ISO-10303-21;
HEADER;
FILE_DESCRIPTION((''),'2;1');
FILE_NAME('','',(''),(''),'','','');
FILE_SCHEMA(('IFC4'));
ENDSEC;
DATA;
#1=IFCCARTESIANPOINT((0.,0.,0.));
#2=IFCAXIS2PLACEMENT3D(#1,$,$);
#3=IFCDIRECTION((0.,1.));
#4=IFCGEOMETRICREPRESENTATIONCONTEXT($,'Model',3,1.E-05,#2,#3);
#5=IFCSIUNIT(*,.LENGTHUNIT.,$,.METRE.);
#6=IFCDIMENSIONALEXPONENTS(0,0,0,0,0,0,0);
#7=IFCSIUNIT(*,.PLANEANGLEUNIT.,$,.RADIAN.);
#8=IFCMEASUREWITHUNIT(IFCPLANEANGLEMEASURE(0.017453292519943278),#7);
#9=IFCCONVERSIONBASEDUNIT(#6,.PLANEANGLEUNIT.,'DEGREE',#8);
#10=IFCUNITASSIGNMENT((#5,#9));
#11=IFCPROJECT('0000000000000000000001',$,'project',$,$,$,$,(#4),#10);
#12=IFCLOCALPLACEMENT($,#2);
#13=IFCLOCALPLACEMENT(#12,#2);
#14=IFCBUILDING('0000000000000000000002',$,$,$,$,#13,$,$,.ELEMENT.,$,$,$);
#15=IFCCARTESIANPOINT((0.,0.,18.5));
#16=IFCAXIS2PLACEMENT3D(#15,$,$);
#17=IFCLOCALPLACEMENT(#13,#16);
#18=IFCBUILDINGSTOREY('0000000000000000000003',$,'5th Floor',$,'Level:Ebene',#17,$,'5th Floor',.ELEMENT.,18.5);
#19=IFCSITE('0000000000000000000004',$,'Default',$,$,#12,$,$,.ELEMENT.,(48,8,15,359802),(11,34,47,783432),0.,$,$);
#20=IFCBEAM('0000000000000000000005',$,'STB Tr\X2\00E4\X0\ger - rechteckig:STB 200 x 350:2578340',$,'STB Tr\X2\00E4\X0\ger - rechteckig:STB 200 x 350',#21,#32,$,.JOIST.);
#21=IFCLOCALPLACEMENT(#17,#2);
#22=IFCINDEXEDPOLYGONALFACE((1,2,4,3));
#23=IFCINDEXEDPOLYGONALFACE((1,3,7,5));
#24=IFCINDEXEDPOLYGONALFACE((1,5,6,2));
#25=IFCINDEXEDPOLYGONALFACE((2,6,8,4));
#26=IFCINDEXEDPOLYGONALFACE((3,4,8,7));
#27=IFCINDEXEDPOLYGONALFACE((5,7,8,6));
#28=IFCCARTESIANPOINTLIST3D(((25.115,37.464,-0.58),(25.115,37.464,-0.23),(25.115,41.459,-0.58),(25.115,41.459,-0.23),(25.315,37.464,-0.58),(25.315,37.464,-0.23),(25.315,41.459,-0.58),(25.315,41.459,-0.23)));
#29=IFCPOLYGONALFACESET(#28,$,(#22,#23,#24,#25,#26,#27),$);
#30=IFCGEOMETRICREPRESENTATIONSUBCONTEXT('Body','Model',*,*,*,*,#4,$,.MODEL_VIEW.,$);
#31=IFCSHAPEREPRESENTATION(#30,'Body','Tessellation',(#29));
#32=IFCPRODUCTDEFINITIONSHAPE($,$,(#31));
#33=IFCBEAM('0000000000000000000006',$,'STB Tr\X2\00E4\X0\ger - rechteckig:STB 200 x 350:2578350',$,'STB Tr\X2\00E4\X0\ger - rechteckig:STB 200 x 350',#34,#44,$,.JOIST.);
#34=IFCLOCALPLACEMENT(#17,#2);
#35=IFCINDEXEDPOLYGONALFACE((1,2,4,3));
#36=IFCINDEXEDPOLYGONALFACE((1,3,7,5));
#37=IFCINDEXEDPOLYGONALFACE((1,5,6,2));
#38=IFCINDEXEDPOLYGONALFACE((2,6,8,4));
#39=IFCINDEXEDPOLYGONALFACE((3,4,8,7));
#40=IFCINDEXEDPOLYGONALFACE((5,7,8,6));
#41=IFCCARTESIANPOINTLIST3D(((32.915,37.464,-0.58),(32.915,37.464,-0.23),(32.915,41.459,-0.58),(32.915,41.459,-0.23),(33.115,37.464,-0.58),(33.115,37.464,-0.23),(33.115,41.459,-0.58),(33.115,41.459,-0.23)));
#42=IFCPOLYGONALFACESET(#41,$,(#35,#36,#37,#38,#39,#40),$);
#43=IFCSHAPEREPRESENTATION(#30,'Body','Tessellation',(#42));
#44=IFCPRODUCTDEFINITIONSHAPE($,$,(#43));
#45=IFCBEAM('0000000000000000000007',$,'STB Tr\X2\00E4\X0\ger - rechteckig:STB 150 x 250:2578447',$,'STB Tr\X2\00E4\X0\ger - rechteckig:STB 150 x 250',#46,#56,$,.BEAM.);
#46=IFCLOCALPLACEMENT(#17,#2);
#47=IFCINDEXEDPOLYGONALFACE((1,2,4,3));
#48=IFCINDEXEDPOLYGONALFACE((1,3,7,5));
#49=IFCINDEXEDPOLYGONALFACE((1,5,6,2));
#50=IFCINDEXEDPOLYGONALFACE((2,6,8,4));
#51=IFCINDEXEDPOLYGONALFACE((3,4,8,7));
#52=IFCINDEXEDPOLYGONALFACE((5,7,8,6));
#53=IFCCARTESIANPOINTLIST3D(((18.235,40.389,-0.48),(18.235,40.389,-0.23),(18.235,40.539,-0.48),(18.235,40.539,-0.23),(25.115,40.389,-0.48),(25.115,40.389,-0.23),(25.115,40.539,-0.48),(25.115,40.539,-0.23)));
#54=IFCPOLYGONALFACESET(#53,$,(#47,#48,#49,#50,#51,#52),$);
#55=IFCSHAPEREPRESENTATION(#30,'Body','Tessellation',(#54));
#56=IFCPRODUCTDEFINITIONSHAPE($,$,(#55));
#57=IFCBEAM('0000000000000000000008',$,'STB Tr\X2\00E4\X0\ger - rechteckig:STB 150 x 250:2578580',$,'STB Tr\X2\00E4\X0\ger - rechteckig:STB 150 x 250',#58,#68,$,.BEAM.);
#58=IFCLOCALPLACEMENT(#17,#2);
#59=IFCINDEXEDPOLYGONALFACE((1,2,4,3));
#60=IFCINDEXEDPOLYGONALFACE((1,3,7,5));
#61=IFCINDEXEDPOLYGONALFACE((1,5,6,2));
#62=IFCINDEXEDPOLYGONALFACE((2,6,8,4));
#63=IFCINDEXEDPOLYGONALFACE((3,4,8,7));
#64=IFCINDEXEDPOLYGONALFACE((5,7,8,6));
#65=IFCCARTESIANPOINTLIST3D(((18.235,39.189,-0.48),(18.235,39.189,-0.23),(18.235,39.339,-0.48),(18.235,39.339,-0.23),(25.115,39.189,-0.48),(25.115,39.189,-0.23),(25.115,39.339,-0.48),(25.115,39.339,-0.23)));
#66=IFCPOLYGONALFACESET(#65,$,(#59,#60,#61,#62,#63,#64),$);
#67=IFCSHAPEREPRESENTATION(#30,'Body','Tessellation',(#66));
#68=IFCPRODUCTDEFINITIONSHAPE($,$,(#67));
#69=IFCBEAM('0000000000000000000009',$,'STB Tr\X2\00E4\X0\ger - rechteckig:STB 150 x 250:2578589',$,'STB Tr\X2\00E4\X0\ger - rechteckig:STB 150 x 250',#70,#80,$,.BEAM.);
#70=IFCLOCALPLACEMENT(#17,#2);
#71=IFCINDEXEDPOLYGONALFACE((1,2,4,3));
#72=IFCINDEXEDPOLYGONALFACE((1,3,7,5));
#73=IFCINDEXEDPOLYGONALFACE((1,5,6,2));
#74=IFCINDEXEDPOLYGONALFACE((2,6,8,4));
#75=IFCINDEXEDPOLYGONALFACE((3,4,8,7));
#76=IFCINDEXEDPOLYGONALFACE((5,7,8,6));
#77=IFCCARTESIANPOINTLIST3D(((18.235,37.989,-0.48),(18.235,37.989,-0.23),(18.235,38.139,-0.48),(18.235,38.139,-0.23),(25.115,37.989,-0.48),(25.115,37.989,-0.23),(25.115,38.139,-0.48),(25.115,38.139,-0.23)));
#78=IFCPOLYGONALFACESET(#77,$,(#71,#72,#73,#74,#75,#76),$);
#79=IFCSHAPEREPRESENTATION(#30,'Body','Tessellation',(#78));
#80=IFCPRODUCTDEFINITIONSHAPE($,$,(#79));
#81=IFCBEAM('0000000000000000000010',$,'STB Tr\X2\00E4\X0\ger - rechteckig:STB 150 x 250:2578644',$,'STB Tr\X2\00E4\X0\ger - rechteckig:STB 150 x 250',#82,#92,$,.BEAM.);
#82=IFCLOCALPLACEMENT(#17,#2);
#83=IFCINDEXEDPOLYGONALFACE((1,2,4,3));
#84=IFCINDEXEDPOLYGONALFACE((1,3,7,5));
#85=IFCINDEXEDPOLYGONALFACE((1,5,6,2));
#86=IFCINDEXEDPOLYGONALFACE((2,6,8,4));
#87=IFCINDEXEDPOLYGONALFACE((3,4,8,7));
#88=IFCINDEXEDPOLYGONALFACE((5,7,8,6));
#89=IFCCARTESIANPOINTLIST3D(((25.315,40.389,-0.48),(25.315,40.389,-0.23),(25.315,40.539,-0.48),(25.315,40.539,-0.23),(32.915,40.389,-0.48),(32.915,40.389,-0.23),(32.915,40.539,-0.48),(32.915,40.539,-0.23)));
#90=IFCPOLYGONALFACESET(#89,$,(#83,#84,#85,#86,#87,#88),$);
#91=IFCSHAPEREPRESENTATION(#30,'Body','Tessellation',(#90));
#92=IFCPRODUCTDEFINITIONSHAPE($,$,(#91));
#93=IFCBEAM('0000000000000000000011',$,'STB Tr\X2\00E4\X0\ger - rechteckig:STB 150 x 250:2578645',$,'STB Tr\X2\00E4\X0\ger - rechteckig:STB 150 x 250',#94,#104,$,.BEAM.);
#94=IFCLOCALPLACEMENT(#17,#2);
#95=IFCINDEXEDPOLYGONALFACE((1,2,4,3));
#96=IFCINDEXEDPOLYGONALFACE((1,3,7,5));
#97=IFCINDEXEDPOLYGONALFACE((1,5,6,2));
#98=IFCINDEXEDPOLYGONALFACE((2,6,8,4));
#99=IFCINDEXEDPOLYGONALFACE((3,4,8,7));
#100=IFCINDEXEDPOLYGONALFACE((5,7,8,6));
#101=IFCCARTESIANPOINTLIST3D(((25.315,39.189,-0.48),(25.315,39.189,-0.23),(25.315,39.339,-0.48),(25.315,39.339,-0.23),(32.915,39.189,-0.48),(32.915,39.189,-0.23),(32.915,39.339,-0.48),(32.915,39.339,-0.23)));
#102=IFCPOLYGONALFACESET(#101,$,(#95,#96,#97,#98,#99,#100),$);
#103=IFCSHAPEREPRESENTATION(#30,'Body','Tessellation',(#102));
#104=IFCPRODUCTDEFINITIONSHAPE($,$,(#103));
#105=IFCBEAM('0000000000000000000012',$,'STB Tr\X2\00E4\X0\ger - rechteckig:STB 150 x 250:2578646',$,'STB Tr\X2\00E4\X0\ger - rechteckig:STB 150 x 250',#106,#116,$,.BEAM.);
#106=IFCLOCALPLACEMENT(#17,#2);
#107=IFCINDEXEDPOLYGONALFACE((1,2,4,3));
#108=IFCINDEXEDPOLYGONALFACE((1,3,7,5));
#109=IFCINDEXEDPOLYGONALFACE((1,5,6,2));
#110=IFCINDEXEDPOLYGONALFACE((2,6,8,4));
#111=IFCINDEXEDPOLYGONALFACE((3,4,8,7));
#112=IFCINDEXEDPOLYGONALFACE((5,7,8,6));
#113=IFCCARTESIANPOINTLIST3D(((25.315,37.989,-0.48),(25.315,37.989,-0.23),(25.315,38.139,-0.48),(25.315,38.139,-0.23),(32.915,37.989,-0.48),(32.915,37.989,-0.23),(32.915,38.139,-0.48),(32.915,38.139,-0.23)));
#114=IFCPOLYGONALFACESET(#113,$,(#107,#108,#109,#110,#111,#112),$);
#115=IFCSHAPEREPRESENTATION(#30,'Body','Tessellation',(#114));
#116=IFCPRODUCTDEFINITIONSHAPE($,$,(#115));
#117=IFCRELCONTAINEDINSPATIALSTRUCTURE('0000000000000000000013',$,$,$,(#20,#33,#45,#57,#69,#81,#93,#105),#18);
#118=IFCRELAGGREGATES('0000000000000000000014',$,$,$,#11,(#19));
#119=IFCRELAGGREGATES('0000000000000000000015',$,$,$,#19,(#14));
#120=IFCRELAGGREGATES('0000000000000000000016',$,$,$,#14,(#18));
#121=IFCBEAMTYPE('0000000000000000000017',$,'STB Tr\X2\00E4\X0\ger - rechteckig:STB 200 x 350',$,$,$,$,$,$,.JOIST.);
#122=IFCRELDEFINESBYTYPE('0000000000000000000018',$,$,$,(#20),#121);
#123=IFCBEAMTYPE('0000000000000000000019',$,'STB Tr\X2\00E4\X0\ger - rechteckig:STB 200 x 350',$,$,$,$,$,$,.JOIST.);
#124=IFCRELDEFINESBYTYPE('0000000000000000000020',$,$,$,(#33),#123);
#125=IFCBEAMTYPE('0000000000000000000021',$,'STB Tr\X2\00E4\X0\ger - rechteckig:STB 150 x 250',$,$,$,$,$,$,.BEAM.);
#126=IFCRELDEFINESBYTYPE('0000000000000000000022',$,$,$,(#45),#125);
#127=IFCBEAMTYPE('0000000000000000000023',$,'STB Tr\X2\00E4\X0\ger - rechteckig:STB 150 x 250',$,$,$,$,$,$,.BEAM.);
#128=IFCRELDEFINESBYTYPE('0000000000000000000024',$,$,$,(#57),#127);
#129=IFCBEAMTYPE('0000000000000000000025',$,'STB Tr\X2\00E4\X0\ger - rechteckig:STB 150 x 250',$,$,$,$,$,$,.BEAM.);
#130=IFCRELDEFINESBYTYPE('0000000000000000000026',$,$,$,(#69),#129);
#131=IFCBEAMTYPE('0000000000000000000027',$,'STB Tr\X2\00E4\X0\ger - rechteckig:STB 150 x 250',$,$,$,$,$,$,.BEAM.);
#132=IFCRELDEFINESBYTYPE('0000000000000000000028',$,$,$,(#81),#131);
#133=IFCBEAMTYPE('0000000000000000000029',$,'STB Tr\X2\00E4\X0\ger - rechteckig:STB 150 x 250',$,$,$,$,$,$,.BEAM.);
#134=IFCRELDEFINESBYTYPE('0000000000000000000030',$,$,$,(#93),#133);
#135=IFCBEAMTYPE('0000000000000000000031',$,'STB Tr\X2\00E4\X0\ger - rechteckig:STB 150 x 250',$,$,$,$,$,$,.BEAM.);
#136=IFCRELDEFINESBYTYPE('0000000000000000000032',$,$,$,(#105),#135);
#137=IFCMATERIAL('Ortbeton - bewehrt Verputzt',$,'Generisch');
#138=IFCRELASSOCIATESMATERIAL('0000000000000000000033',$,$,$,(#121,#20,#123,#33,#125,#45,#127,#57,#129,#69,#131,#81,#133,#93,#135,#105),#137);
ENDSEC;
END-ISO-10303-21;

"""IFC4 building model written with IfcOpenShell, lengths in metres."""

from ifc_helpers import new_model, entity, si_unit, converted_unit, direction, frame, origin, place, context, subcontext, project, spatial, indexed_curve, outline, extrude, source, transform, mapped, material, type_object, type_shapes, element, save


model = new_model("IFC4")

# Units and contexts
model_context = context("Model", 3, precision=1e-05, world=origin(), true_north=direction((0.0, 1.0)))
body_context = subcontext(model_context, "Body", "Model", "MODEL_VIEW")
ifc_project = project(units=[si_unit("LENGTHUNIT", "METRE"), converted_unit("PLANEANGLEUNIT", "DEGREE", entity("IfcPlaneAngleMeasure", 0.017453292519943278), si_unit("PLANEANGLEUNIT", "RADIAN"), dimensions=[0, 0, 0, 0, 0, 0, 0])], contexts=[model_context])

# Site, building, storey
site_placement = place(None, origin())
site = spatial("IfcSite", under=ifc_project, at=site_placement, Name="Default", CompositionType="ELEMENT", RefLatitude=(48, 8, 15, 359802), RefLongitude=(11, 34, 47, 783432), RefElevation=0.0)
building_placement = place(site_placement, origin())
building = spatial("IfcBuilding", under=site, at=building_placement, CompositionType="ELEMENT")
storey_placement = place(building_placement, frame((0.0, 0.0, 18.5)))
storey = spatial("IfcBuildingStorey", under=building, at=storey_placement, Name="5th Floor", ObjectType="Level:Ebene", LongName="5th Floor", CompositionType="ELEMENT", Elevation=18.5)

# Beams
ifc_material_1 = material(Name="Ortbeton - bewehrt Verputzt", Category="Generisch")
beam_type_1 = type_object("IfcBeamType", Name="STB Träger - rechteckig:STB 200 x 350", PredefinedType="JOIST", material=ifc_material_1)
shared_shape_1 = source(origin(), body_context, "Body", "SweptSolid", [
    extrude(outline(indexed_curve([(-0.1, -0.175), (0.1, -0.175), (0.1, 0.175), (-0.1, 0.175), (-0.1, -0.175)], self_intersect=False)), frame((25.215, 41.459, 18.095), z_axis=(0.0, -1.0, 0.0), x_axis=(-1.0, 0.0, 0.0)), (0.0, 0.0, 1.0), 3.995),
])
type_shapes(beam_type_1, [shared_shape_1])
beam_1_placement = place(storey_placement, frame((0.0, 0.0, -18.5)))
element("IfcBeam", 1, at=beam_1_placement, inside=storey, type_object=beam_type_1, material=ifc_material_1, Name="STB Träger - rechteckig:STB 200 x 350:2578340", ObjectType="STB Träger - rechteckig:STB 200 x 350", PredefinedType="JOIST", context=body_context, shape_type="MappedRepresentation", body=[
    mapped(shared_shape_1, transform((0.0, 0.0, 0.0), scale=1.0)),
])
beam_type_2 = type_object("IfcBeamType", Name="STB Träger - rechteckig:STB 200 x 350", PredefinedType="JOIST", material=ifc_material_1)
shared_shape_2 = source(origin(), body_context, "Body", "SweptSolid", [
    extrude(outline(indexed_curve([(-0.1, -0.175), (0.1, -0.175), (0.1, 0.175), (-0.1, 0.175), (-0.1, -0.175)], self_intersect=False)), frame((33.015, 41.459, 18.095), z_axis=(0.0, -1.0, 0.0), x_axis=(-1.0, 0.0, 0.0)), (0.0, 0.0, 1.0), 3.995),
])
type_shapes(beam_type_2, [shared_shape_2])
beam_2_placement = place(storey_placement, frame((0.0, 0.0, -18.5)))
element("IfcBeam", 2, at=beam_2_placement, inside=storey, type_object=beam_type_2, material=ifc_material_1, Name="STB Träger - rechteckig:STB 200 x 350:2578350", ObjectType="STB Träger - rechteckig:STB 200 x 350", PredefinedType="JOIST", context=body_context, shape_type="MappedRepresentation", body=[
    mapped(shared_shape_2, transform((0.0, 0.0, 0.0), scale=1.0)),
])
beam_type_3 = type_object("IfcBeamType", Name="STB Träger - rechteckig:STB 150 x 250", PredefinedType="BEAM", material=ifc_material_1)
shared_shape_3 = source(origin(), body_context, "Body", "SweptSolid", [
    extrude(outline(indexed_curve([(-0.125, -0.075), (0.125, -0.075), (0.125, 0.075), (-0.125, 0.075), (-0.125, -0.075)], self_intersect=False)), frame((18.235, 40.464, 18.145), z_axis=(1.0, 0.0, 0.0), x_axis=(0.0, 0.0, -1.0)), (0.0, 0.0, 1.0), 6.88),
])
type_shapes(beam_type_3, [shared_shape_3])
beam_3_placement = place(storey_placement, frame((0.0, 0.0, -18.5)))
element("IfcBeam", 3, at=beam_3_placement, inside=storey, type_object=beam_type_3, material=ifc_material_1, Name="STB Träger - rechteckig:STB 150 x 250:2578447", ObjectType="STB Träger - rechteckig:STB 150 x 250", PredefinedType="BEAM", context=body_context, shape_type="MappedRepresentation", body=[
    mapped(shared_shape_3, transform((0.0, 0.0, 0.0), scale=1.0)),
])
beam_type_4 = type_object("IfcBeamType", Name="STB Träger - rechteckig:STB 150 x 250", PredefinedType="BEAM", material=ifc_material_1)
shared_shape_4 = source(origin(), body_context, "Body", "SweptSolid", [
    extrude(outline(indexed_curve([(-0.125, -0.075), (0.125, -0.075), (0.125, 0.075), (-0.125, 0.075), (-0.125, -0.075)], self_intersect=False)), frame((18.235, 39.264, 18.145), z_axis=(1.0, 0.0, 0.0), x_axis=(0.0, 0.0, -1.0)), (0.0, 0.0, 1.0), 6.88),
])
type_shapes(beam_type_4, [shared_shape_4])
beam_4_placement = place(storey_placement, frame((0.0, 0.0, -18.5)))
element("IfcBeam", 4, at=beam_4_placement, inside=storey, type_object=beam_type_4, material=ifc_material_1, Name="STB Träger - rechteckig:STB 150 x 250:2578580", ObjectType="STB Träger - rechteckig:STB 150 x 250", PredefinedType="BEAM", context=body_context, shape_type="MappedRepresentation", body=[
    mapped(shared_shape_4, transform((0.0, 0.0, 0.0), scale=1.0)),
])
beam_type_5 = type_object("IfcBeamType", Name="STB Träger - rechteckig:STB 150 x 250", PredefinedType="BEAM", material=ifc_material_1)
shared_shape_5 = source(origin(), body_context, "Body", "SweptSolid", [
    extrude(outline(indexed_curve([(-0.125, -0.075), (0.125, -0.075), (0.125, 0.075), (-0.125, 0.075), (-0.125, -0.075)], self_intersect=False)), frame((18.235, 38.064, 18.145), z_axis=(1.0, 0.0, 0.0), x_axis=(0.0, 0.0, -1.0)), (0.0, 0.0, 1.0), 6.88),
])
type_shapes(beam_type_5, [shared_shape_5])
beam_5_placement = place(storey_placement, frame((0.0, 0.0, -18.5)))
element("IfcBeam", 5, at=beam_5_placement, inside=storey, type_object=beam_type_5, material=ifc_material_1, Name="STB Träger - rechteckig:STB 150 x 250:2578589", ObjectType="STB Träger - rechteckig:STB 150 x 250", PredefinedType="BEAM", context=body_context, shape_type="MappedRepresentation", body=[
    mapped(shared_shape_5, transform((0.0, 0.0, 0.0), scale=1.0)),
])
beam_type_6 = type_object("IfcBeamType", Name="STB Träger - rechteckig:STB 150 x 250", PredefinedType="BEAM", material=ifc_material_1)
shared_shape_6 = source(origin(), body_context, "Body", "SweptSolid", [
    extrude(outline(indexed_curve([(-0.125, -0.075), (0.125, -0.075), (0.125, 0.075), (-0.125, 0.075), (-0.125, -0.075)], self_intersect=False)), frame((25.315, 40.464, 18.145), z_axis=(1.0, 0.0, 0.0), x_axis=(0.0, 0.0, -1.0)), (0.0, 0.0, 1.0), 7.6),
])
type_shapes(beam_type_6, [shared_shape_6])
beam_6_placement = place(storey_placement, frame((0.0, 0.0, -18.5)))
element("IfcBeam", 6, at=beam_6_placement, inside=storey, type_object=beam_type_6, material=ifc_material_1, Name="STB Träger - rechteckig:STB 150 x 250:2578644", ObjectType="STB Träger - rechteckig:STB 150 x 250", PredefinedType="BEAM", context=body_context, shape_type="MappedRepresentation", body=[
    mapped(shared_shape_6, transform((0.0, 0.0, 0.0), scale=1.0)),
])
beam_type_7 = type_object("IfcBeamType", Name="STB Träger - rechteckig:STB 150 x 250", PredefinedType="BEAM", material=ifc_material_1)
shared_shape_7 = source(origin(), body_context, "Body", "SweptSolid", [
    extrude(outline(indexed_curve([(-0.125, -0.075), (0.125, -0.075), (0.125, 0.075), (-0.125, 0.075), (-0.125, -0.075)], self_intersect=False)), frame((25.315, 39.264, 18.145), z_axis=(1.0, 0.0, 0.0), x_axis=(0.0, 0.0, -1.0)), (0.0, 0.0, 1.0), 7.6),
])
type_shapes(beam_type_7, [shared_shape_7])
beam_7_placement = place(storey_placement, frame((0.0, 0.0, -18.5)))
element("IfcBeam", 7, at=beam_7_placement, inside=storey, type_object=beam_type_7, material=ifc_material_1, Name="STB Träger - rechteckig:STB 150 x 250:2578645", ObjectType="STB Träger - rechteckig:STB 150 x 250", PredefinedType="BEAM", context=body_context, shape_type="MappedRepresentation", body=[
    mapped(shared_shape_7, transform((0.0, 0.0, 0.0), scale=1.0)),
])
beam_type_8 = type_object("IfcBeamType", Name="STB Träger - rechteckig:STB 150 x 250", PredefinedType="BEAM", material=ifc_material_1)
shared_shape_8 = source(origin(), body_context, "Body", "SweptSolid", [
    extrude(outline(indexed_curve([(-0.125, -0.075), (0.125, -0.075), (0.125, 0.075), (-0.125, 0.075), (-0.125, -0.075)], self_intersect=False)), frame((25.315, 38.064, 18.145), z_axis=(1.0, 0.0, 0.0), x_axis=(0.0, 0.0, -1.0)), (0.0, 0.0, 1.0), 7.6),
])
type_shapes(beam_type_8, [shared_shape_8])
beam_8_placement = place(storey_placement, frame((0.0, 0.0, -18.5)))
element("IfcBeam", 8, at=beam_8_placement, inside=storey, type_object=beam_type_8, material=ifc_material_1, Name="STB Träger - rechteckig:STB 150 x 250:2578646", ObjectType="STB Träger - rechteckig:STB 150 x 250", PredefinedType="BEAM", context=body_context, shape_type="MappedRepresentation", body=[
    mapped(shared_shape_8, transform((0.0, 0.0, 0.0), scale=1.0)),
])

save(model, "model.ifc")
